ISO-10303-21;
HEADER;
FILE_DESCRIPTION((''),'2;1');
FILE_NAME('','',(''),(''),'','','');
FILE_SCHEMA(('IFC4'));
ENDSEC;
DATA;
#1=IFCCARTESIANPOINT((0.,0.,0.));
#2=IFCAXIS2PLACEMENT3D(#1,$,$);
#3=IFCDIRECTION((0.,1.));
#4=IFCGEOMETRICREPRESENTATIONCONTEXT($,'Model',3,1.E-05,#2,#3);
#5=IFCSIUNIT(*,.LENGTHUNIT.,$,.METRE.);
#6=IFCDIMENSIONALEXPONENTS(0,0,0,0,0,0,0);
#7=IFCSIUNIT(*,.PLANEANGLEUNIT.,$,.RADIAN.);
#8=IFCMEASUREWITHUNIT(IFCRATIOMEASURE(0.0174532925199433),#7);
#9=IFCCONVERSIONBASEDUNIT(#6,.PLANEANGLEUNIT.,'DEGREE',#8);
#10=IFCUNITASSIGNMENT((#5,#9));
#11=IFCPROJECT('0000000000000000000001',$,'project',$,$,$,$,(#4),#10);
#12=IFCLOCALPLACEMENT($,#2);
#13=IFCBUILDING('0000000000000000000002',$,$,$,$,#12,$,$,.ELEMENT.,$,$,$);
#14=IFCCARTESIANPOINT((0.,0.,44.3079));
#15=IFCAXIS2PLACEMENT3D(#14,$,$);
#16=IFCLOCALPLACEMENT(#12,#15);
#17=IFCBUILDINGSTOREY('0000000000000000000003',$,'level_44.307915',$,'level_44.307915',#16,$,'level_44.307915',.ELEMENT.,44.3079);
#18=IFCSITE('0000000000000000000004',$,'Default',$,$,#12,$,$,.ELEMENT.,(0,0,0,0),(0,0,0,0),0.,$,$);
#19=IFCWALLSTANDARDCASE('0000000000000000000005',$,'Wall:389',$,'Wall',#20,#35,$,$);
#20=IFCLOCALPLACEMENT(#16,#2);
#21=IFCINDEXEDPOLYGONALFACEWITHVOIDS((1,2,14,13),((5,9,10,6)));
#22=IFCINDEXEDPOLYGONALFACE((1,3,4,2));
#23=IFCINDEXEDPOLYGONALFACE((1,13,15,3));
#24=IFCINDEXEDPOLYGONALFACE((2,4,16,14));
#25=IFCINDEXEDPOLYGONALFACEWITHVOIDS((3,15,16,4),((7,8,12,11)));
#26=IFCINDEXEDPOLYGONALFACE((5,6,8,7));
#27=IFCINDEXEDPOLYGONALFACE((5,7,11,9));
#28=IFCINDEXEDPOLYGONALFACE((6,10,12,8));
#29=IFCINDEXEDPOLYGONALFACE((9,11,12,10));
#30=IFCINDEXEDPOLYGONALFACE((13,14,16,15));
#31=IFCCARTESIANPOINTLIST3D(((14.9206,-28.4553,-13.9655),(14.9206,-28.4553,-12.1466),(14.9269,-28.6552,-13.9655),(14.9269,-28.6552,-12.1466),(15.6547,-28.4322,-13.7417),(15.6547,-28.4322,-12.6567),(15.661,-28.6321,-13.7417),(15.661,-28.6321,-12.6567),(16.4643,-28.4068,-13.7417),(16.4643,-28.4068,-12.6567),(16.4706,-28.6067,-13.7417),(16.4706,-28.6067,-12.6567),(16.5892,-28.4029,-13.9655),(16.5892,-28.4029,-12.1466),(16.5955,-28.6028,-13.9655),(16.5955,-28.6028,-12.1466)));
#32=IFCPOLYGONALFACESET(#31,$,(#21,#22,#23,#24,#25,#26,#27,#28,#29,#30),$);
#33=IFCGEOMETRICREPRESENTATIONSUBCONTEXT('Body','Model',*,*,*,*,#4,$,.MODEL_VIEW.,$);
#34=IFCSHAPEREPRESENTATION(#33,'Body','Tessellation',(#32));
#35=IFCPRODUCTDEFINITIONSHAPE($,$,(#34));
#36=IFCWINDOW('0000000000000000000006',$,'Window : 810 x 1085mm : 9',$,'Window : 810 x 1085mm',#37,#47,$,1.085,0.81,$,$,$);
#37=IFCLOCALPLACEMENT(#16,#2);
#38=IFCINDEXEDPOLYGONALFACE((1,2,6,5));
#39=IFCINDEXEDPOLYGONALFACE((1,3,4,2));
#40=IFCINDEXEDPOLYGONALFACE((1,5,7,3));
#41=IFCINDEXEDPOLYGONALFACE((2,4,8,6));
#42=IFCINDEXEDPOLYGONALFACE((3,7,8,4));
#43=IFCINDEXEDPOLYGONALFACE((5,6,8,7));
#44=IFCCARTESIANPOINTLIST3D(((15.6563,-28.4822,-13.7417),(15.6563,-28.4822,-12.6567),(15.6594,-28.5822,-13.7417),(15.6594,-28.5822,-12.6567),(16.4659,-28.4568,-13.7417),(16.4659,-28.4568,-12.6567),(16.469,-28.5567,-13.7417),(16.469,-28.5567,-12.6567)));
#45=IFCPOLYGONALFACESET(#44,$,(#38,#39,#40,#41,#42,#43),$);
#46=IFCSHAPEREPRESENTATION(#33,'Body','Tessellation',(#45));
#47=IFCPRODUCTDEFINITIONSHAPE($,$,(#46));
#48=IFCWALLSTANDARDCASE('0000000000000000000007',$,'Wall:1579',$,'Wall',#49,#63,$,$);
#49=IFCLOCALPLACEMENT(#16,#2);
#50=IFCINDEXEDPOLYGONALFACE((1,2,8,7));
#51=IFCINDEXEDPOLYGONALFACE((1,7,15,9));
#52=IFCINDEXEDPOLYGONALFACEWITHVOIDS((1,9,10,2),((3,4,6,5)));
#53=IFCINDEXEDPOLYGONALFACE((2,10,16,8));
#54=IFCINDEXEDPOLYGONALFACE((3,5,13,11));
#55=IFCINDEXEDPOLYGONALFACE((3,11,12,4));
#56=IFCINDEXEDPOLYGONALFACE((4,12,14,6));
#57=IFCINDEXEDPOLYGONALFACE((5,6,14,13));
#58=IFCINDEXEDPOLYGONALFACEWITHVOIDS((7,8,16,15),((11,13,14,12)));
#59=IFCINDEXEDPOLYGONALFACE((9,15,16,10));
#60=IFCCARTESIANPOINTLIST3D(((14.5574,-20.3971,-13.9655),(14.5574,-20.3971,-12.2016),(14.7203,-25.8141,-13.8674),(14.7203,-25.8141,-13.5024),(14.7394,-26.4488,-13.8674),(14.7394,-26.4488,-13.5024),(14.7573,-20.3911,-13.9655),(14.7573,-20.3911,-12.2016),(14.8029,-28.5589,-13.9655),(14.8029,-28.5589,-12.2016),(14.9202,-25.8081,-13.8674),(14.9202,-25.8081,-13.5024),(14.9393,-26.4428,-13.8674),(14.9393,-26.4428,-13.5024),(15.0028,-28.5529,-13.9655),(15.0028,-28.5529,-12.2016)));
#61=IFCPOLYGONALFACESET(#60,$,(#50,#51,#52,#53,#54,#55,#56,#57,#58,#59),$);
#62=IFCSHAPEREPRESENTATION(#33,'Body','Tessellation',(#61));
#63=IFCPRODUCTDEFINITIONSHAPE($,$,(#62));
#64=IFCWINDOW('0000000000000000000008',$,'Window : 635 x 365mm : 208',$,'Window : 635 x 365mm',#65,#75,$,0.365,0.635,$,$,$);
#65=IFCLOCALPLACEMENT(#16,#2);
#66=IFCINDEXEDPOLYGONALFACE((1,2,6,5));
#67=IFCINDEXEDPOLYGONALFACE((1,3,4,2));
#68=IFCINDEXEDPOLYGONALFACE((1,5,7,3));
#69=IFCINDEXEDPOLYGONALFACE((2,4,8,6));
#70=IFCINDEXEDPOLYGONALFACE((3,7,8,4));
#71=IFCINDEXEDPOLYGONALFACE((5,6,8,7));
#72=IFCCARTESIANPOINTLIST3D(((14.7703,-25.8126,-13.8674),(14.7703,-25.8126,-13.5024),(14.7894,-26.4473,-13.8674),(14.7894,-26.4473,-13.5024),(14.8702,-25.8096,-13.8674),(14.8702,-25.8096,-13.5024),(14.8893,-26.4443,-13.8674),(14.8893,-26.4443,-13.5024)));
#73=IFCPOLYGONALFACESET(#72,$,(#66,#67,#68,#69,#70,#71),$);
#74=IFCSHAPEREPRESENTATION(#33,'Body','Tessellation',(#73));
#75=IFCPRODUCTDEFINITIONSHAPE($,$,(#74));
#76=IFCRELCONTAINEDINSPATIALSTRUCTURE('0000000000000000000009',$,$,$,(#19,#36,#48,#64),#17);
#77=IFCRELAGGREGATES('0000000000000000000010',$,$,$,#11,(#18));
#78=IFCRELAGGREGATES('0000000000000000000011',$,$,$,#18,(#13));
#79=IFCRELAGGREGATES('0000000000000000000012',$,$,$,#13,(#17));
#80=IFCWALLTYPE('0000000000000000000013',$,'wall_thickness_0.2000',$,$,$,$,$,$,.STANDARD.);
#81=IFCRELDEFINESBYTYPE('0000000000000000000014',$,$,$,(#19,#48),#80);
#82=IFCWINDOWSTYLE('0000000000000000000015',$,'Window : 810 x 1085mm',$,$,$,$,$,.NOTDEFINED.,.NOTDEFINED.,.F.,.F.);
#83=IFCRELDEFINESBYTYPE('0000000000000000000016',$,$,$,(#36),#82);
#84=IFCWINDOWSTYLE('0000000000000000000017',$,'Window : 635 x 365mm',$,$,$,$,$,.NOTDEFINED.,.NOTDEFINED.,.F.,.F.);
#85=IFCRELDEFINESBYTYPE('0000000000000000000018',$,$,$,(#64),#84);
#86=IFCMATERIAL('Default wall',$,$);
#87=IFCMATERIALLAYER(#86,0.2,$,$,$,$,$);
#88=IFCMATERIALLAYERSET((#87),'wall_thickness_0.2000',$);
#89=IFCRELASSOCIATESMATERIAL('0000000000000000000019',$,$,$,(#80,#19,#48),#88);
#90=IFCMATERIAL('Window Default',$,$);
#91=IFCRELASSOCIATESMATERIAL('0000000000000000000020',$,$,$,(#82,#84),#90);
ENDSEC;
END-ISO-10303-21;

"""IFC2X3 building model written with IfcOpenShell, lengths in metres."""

from ifc_helpers import new_model, entity, si_unit, converted_unit, direction, frame, frame_2d, origin, origin_2d_with_axis, place, context, subcontext, project, spatial, polyline, rectangle, outline, extrude, source, transform, mapped, material, layer, layer_set, layer_usage, type_object, type_shapes, element, fill, save


model = new_model("IFC2X3")

# Units and contexts
model_context = context("Model", 3, precision=1e-05, world=origin(), true_north=direction((0.0, 1.0)))
body_context = subcontext(model_context, "Body", "Model", "MODEL_VIEW")
ifc_project = project(units=[si_unit("LENGTHUNIT", "METRE"), converted_unit("PLANEANGLEUNIT", "DEGREE", entity("IfcRatioMeasure", 0.0174532925199433), si_unit("PLANEANGLEUNIT", "RADIAN"), dimensions=[0, 0, 0, 0, 0, 0, 0])], contexts=[model_context])

# Site, building, storey
placement_1 = place(None, origin())
site = spatial("IfcSite", under=ifc_project, at=placement_1, Name="Default", CompositionType="ELEMENT", RefLatitude=(0, 0, 0, 0), RefLongitude=(0, 0, 0, 0), RefElevation=0.0)
building = spatial("IfcBuilding", under=site, at=placement_1, CompositionType="ELEMENT")
storey_placement = place(placement_1, frame((0.0, 0.0, 44.3079)))
storey = spatial("IfcBuildingStorey", under=building, at=storey_placement, Name="level_44.307915", ObjectType="level_44.307915", LongName="level_44.307915", CompositionType="ELEMENT", Elevation=44.3079)

# Walls, openings, windows
ifc_material_1 = material(Name="Default wall")
ifc_layer = layer(ifc_material_1, 0.2)
ifc_layer_set = layer_set([ifc_layer], Name="wall_thickness_0.2000")
ifc_layer_usage = layer_usage(ifc_layer_set, "AXIS2", "POSITIVE", -0.1)
wall_type = type_object("IfcWallType", Name="wall_thickness_0.2000", PredefinedType="STANDARD", material=ifc_layer_set)
placement_2 = place(placement_1, frame((0.0, 0.0, 30.3424)))
wall_1_placement = place(placement_2, frame((14.9237, -28.5553, 0.0), z_axis=(0.0, 0.0, 1.0), x_axis=(0.999506, 0.031414, 0.0)))
wall_1 = element("IfcWallStandardCase", 1, at=wall_1_placement, inside=storey, type_object=wall_type, material=ifc_layer_usage, Name="Wall:389", ObjectType="Wall", context=body_context, shape_type="SweptSolid", body=[
    extrude(outline(polyline([(1.6695, -0.1), (1.6695, 0.1), (0.0, 0.1), (0.0, -0.1), (1.6695, -0.1)])), origin(), (0.0, 0.0, 1.0), 1.8189),
])
opening_1_placement = place(wall_1_placement, frame((0.7345, -0.1, 0.2238)))
opening_1 = element("IfcOpeningElement", 2, at=opening_1_placement, cuts=wall_1, ObjectType="Opening", context=body_context, shape_type="SweptSolid", body=[
    extrude(rectangle(XDim=0.81, YDim=1.085, at=frame_2d((0.5425, 0.405), x_axis=(0.0, 1.0))), frame((0.0, 0.0, 0.0), z_axis=(0.0, 1.0, 0.0), x_axis=(0.0, 0.0, 1.0)), (0.0, 0.0, 1.0), 0.2),
])
ifc_material_2 = material(Name="Window Default")
window_style_1 = type_object("IfcWindowStyle", Name="Window : 810 x 1085mm", ConstructionType="NOTDEFINED", OperationType="NOTDEFINED", ParameterTakesPrecedence=False, Sizeable=False, material=ifc_material_2)
shared_shape_1 = source(origin(), body_context, "Body", "SweptSolid", [
    extrude(rectangle(XDim=0.1, YDim=0.81, at=origin_2d_with_axis()), frame((0.405, 0.1, 0.0), z_axis=(0.0, 0.0, 1.0), x_axis=(0.0, 1.0, 0.0)), (0.0, 0.0, 1.0), 1.085),
])
type_shapes(window_style_1, [shared_shape_1])
window_1_placement = place(opening_1_placement, origin())
window_1 = element("IfcWindow", 3, at=window_1_placement, inside=storey, type_object=window_style_1, Name="Window : 810 x 1085mm : 9", ObjectType="Window : 810 x 1085mm", OverallHeight=1.085, OverallWidth=0.81, context=body_context, shape_type="MappedRepresentation", body=[
    mapped(shared_shape_1, transform((0.0, 0.0, 0.0), scale=1.0)),
])
fill(opening_1, window_1)
placement_3 = place(placement_1, frame((0.0, 0.0, 30.3424)))
wall_2_placement = place(placement_3, frame((14.9028, -28.5559, 0.0), z_axis=(0.0, 0.0, 1.0), x_axis=(-0.030056, 0.999548, 0.0)))
wall_2 = element("IfcWallStandardCase", 4, at=wall_2_placement, inside=storey, type_object=wall_type, material=ifc_layer_usage, Name="Wall:1579", ObjectType="Wall", context=body_context, shape_type="SweptSolid", body=[
    extrude(outline(polyline([(8.1655, -0.1), (8.1655, 0.1), (0.0, 0.1), (0.0, -0.1), (8.1655, -0.1)])), origin(), (0.0, 0.0, 1.0), 1.7639),
])
opening_2_placement = place(wall_2_placement, frame((2.1111, -0.1, 0.0982)))
opening_2 = element("IfcOpeningElement", 5, at=opening_2_placement, cuts=wall_2, ObjectType="Opening", context=body_context, shape_type="SweptSolid", body=[
    extrude(rectangle(XDim=0.635, YDim=0.365, at=frame_2d((0.1825, 0.3175), x_axis=(0.0, 1.0))), frame((0.0, 0.0, 0.0), z_axis=(0.0, 1.0, 0.0), x_axis=(0.0, 0.0, 1.0)), (0.0, 0.0, 1.0), 0.2),
])
window_style_2 = type_object("IfcWindowStyle", Name="Window : 635 x 365mm", ConstructionType="NOTDEFINED", OperationType="NOTDEFINED", ParameterTakesPrecedence=False, Sizeable=False, material=ifc_material_2)
shared_shape_2 = source(origin(), body_context, "Body", "SweptSolid", [
    extrude(rectangle(XDim=0.1, YDim=0.635, at=origin_2d_with_axis()), frame((0.3175, 0.1, 0.0), z_axis=(0.0, 0.0, 1.0), x_axis=(0.0, 1.0, 0.0)), (0.0, 0.0, 1.0), 0.365),
])
type_shapes(window_style_2, [shared_shape_2])
window_2_placement = place(opening_2_placement, origin())
window_2 = element("IfcWindow", 6, at=window_2_placement, inside=storey, type_object=window_style_2, Name="Window : 635 x 365mm : 208", ObjectType="Window : 635 x 365mm", OverallHeight=0.365, OverallWidth=0.635, context=body_context, shape_type="MappedRepresentation", body=[
    mapped(shared_shape_2, transform((0.0, 0.0, 0.0), scale=1.0)),
])
fill(opening_2, window_2)

save(model, "model.ifc")
